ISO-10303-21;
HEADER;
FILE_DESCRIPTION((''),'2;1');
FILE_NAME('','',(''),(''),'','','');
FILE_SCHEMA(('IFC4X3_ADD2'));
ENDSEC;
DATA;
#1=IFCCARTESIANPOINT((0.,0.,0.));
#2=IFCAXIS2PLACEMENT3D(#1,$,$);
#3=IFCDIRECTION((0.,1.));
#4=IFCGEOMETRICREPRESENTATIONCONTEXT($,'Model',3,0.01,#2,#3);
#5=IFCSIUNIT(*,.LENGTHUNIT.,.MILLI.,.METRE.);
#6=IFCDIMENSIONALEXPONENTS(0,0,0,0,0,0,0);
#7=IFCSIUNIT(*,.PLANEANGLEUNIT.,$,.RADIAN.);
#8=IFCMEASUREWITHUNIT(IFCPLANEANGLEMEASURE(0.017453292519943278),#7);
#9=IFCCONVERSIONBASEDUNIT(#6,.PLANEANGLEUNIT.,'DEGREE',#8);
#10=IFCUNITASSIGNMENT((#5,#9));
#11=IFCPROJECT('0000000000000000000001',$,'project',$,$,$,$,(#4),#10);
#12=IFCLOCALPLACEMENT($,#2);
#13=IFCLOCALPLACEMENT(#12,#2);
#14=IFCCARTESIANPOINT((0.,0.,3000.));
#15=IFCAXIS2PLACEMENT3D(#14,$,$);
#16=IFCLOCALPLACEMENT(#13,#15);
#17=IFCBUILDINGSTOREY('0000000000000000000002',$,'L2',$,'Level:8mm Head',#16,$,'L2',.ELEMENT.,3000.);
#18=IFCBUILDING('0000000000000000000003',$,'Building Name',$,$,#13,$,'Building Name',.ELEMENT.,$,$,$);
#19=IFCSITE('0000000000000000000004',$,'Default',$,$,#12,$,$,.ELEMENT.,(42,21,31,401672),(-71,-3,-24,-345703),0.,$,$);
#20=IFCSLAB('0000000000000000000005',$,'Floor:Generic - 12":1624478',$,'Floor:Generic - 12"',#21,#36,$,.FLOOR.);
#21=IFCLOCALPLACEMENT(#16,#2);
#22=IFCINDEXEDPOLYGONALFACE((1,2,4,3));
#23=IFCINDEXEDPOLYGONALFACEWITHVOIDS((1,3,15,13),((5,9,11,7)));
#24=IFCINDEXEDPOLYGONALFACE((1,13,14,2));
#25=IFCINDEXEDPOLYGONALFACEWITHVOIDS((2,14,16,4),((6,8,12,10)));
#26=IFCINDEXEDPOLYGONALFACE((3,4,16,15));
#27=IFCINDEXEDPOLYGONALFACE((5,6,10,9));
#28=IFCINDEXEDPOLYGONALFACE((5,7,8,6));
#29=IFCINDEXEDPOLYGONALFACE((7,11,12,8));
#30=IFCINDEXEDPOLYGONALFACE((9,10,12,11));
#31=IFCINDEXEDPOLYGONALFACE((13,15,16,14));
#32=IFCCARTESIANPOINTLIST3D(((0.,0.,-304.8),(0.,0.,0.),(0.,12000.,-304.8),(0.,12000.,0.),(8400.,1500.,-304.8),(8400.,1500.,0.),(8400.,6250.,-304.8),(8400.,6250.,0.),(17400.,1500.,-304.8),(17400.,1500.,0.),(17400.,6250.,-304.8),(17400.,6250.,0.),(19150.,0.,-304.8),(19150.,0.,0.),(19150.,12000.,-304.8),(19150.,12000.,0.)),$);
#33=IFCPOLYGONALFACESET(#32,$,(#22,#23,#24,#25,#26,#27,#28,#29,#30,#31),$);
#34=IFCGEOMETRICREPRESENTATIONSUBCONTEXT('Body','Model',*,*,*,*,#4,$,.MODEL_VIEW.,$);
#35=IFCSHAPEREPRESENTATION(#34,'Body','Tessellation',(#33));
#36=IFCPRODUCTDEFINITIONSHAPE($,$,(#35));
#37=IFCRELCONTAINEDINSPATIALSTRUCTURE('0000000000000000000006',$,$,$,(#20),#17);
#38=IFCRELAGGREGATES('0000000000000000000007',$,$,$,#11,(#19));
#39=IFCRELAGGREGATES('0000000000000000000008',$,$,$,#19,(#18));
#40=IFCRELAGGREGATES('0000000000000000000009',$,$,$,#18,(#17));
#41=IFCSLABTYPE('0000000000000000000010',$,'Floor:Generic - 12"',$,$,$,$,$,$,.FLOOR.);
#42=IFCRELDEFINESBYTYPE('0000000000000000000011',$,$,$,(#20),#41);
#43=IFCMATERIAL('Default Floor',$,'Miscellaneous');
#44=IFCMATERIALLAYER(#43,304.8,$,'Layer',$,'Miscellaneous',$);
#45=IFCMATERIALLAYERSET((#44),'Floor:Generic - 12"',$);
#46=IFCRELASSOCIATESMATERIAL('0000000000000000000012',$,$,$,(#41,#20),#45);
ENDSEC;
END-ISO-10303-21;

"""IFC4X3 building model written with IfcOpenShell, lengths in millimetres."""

from ifc_helpers import new_model, entity, si_unit, converted_unit, direction, frame, frame_2d, origin, place, context, subcontext, project, spatial, rectangle, extrude, boolean, material, layer, layer_set, layer_usage, type_object, element, save


model = new_model("IFC4X3")

# Units and contexts
model_context = context("Model", 3, precision=0.01, world=origin(), true_north=direction((0.0, 1.0)))
body_context = subcontext(model_context, "Body", "Model", "MODEL_VIEW")
ifc_project = project(units=[si_unit("LENGTHUNIT", "METRE", prefix="MILLI"), converted_unit("PLANEANGLEUNIT", "DEGREE", entity("IfcPlaneAngleMeasure", 0.017453292519943278), si_unit("PLANEANGLEUNIT", "RADIAN"), dimensions=[0, 0, 0, 0, 0, 0, 0])], contexts=[model_context])

# Site, building, storey
site_placement = place(None, origin())
site = spatial("IfcSite", under=ifc_project, at=site_placement, Name="Default", CompositionType="ELEMENT", RefLatitude=(42, 21, 31, 401672), RefLongitude=(-71, -3, -24, -345703), RefElevation=0.0)
building_placement = place(site_placement, origin())
building = spatial("IfcBuilding", under=site, at=building_placement, Name="Building Name", LongName="Building Name", CompositionType="ELEMENT")
storey_placement = place(building_placement, frame((0.0, 0.0, 3000.0)))
storey = spatial("IfcBuildingStorey", under=building, at=storey_placement, Name="L2", ObjectType="Level:8mm Head", LongName="L2", CompositionType="ELEMENT", Elevation=3000.0)

# Slab, opening
ifc_material = material(Name="Default Floor", Category="Miscellaneous")
ifc_layer = layer(ifc_material, 304.8, Name="Layer", Category="Miscellaneous")
ifc_layer_set = layer_set([ifc_layer], Name="Floor:Generic - 12\"")
ifc_layer_usage = layer_usage(ifc_layer_set, "AXIS3", "POSITIVE", 0.0)
slab_type = type_object("IfcSlabType", Name="Floor:Generic - 12\"", PredefinedType="FLOOR", material=ifc_layer_set)
slab_placement = place(storey_placement, origin())
slab = element("IfcSlab", 1, at=slab_placement, inside=storey, type_object=slab_type, material=ifc_layer_usage, Name="Floor:Generic - 12\":1624478", ObjectType="Floor:Generic - 12\"", PredefinedType="FLOOR", context=body_context, shape_type="SweptSolid", body=[
    boolean("DIFFERENCE", extrude(rectangle(XDim=12000.0, YDim=19150.0, at=frame_2d((0.0, 0.0), x_axis=(1.0, 0.0))), frame((9575.0, 6000.0, 0.0), z_axis=(0.0, 0.0, -1.0), x_axis=(0.0, 1.0, 0.0)), (0.0, 0.0, 1.0), 304.8), extrude(rectangle(XDim=4750.0, YDim=9000.0, at=frame_2d((0.0, 0.0), x_axis=(1.0, 0.0))), frame((12900.0, 3875.0, 0.0), z_axis=(0.0, 0.0, -1.0), x_axis=(0.0, -1.0, 0.0)), (0.0, 0.0, 1.0), 304.8)),
])
opening_placement = place(slab_placement, origin())
element("IfcOpeningElement", 2, at=opening_placement, cuts=slab, PredefinedType="OPENING", context=body_context, shape_type="SweptSolid", body=[
    extrude(rectangle(XDim=4750.0, YDim=9000.0, at=frame_2d((0.0, 0.0), x_axis=(1.0, 0.0))), frame((12900.0, 3875.0, -304.8), z_axis=(0.0, 0.0, 1.0), x_axis=(0.0, -1.0, 0.0)), (0.0, 0.0, 1.0), 304.8),
])

save(model, "model.ifc")
